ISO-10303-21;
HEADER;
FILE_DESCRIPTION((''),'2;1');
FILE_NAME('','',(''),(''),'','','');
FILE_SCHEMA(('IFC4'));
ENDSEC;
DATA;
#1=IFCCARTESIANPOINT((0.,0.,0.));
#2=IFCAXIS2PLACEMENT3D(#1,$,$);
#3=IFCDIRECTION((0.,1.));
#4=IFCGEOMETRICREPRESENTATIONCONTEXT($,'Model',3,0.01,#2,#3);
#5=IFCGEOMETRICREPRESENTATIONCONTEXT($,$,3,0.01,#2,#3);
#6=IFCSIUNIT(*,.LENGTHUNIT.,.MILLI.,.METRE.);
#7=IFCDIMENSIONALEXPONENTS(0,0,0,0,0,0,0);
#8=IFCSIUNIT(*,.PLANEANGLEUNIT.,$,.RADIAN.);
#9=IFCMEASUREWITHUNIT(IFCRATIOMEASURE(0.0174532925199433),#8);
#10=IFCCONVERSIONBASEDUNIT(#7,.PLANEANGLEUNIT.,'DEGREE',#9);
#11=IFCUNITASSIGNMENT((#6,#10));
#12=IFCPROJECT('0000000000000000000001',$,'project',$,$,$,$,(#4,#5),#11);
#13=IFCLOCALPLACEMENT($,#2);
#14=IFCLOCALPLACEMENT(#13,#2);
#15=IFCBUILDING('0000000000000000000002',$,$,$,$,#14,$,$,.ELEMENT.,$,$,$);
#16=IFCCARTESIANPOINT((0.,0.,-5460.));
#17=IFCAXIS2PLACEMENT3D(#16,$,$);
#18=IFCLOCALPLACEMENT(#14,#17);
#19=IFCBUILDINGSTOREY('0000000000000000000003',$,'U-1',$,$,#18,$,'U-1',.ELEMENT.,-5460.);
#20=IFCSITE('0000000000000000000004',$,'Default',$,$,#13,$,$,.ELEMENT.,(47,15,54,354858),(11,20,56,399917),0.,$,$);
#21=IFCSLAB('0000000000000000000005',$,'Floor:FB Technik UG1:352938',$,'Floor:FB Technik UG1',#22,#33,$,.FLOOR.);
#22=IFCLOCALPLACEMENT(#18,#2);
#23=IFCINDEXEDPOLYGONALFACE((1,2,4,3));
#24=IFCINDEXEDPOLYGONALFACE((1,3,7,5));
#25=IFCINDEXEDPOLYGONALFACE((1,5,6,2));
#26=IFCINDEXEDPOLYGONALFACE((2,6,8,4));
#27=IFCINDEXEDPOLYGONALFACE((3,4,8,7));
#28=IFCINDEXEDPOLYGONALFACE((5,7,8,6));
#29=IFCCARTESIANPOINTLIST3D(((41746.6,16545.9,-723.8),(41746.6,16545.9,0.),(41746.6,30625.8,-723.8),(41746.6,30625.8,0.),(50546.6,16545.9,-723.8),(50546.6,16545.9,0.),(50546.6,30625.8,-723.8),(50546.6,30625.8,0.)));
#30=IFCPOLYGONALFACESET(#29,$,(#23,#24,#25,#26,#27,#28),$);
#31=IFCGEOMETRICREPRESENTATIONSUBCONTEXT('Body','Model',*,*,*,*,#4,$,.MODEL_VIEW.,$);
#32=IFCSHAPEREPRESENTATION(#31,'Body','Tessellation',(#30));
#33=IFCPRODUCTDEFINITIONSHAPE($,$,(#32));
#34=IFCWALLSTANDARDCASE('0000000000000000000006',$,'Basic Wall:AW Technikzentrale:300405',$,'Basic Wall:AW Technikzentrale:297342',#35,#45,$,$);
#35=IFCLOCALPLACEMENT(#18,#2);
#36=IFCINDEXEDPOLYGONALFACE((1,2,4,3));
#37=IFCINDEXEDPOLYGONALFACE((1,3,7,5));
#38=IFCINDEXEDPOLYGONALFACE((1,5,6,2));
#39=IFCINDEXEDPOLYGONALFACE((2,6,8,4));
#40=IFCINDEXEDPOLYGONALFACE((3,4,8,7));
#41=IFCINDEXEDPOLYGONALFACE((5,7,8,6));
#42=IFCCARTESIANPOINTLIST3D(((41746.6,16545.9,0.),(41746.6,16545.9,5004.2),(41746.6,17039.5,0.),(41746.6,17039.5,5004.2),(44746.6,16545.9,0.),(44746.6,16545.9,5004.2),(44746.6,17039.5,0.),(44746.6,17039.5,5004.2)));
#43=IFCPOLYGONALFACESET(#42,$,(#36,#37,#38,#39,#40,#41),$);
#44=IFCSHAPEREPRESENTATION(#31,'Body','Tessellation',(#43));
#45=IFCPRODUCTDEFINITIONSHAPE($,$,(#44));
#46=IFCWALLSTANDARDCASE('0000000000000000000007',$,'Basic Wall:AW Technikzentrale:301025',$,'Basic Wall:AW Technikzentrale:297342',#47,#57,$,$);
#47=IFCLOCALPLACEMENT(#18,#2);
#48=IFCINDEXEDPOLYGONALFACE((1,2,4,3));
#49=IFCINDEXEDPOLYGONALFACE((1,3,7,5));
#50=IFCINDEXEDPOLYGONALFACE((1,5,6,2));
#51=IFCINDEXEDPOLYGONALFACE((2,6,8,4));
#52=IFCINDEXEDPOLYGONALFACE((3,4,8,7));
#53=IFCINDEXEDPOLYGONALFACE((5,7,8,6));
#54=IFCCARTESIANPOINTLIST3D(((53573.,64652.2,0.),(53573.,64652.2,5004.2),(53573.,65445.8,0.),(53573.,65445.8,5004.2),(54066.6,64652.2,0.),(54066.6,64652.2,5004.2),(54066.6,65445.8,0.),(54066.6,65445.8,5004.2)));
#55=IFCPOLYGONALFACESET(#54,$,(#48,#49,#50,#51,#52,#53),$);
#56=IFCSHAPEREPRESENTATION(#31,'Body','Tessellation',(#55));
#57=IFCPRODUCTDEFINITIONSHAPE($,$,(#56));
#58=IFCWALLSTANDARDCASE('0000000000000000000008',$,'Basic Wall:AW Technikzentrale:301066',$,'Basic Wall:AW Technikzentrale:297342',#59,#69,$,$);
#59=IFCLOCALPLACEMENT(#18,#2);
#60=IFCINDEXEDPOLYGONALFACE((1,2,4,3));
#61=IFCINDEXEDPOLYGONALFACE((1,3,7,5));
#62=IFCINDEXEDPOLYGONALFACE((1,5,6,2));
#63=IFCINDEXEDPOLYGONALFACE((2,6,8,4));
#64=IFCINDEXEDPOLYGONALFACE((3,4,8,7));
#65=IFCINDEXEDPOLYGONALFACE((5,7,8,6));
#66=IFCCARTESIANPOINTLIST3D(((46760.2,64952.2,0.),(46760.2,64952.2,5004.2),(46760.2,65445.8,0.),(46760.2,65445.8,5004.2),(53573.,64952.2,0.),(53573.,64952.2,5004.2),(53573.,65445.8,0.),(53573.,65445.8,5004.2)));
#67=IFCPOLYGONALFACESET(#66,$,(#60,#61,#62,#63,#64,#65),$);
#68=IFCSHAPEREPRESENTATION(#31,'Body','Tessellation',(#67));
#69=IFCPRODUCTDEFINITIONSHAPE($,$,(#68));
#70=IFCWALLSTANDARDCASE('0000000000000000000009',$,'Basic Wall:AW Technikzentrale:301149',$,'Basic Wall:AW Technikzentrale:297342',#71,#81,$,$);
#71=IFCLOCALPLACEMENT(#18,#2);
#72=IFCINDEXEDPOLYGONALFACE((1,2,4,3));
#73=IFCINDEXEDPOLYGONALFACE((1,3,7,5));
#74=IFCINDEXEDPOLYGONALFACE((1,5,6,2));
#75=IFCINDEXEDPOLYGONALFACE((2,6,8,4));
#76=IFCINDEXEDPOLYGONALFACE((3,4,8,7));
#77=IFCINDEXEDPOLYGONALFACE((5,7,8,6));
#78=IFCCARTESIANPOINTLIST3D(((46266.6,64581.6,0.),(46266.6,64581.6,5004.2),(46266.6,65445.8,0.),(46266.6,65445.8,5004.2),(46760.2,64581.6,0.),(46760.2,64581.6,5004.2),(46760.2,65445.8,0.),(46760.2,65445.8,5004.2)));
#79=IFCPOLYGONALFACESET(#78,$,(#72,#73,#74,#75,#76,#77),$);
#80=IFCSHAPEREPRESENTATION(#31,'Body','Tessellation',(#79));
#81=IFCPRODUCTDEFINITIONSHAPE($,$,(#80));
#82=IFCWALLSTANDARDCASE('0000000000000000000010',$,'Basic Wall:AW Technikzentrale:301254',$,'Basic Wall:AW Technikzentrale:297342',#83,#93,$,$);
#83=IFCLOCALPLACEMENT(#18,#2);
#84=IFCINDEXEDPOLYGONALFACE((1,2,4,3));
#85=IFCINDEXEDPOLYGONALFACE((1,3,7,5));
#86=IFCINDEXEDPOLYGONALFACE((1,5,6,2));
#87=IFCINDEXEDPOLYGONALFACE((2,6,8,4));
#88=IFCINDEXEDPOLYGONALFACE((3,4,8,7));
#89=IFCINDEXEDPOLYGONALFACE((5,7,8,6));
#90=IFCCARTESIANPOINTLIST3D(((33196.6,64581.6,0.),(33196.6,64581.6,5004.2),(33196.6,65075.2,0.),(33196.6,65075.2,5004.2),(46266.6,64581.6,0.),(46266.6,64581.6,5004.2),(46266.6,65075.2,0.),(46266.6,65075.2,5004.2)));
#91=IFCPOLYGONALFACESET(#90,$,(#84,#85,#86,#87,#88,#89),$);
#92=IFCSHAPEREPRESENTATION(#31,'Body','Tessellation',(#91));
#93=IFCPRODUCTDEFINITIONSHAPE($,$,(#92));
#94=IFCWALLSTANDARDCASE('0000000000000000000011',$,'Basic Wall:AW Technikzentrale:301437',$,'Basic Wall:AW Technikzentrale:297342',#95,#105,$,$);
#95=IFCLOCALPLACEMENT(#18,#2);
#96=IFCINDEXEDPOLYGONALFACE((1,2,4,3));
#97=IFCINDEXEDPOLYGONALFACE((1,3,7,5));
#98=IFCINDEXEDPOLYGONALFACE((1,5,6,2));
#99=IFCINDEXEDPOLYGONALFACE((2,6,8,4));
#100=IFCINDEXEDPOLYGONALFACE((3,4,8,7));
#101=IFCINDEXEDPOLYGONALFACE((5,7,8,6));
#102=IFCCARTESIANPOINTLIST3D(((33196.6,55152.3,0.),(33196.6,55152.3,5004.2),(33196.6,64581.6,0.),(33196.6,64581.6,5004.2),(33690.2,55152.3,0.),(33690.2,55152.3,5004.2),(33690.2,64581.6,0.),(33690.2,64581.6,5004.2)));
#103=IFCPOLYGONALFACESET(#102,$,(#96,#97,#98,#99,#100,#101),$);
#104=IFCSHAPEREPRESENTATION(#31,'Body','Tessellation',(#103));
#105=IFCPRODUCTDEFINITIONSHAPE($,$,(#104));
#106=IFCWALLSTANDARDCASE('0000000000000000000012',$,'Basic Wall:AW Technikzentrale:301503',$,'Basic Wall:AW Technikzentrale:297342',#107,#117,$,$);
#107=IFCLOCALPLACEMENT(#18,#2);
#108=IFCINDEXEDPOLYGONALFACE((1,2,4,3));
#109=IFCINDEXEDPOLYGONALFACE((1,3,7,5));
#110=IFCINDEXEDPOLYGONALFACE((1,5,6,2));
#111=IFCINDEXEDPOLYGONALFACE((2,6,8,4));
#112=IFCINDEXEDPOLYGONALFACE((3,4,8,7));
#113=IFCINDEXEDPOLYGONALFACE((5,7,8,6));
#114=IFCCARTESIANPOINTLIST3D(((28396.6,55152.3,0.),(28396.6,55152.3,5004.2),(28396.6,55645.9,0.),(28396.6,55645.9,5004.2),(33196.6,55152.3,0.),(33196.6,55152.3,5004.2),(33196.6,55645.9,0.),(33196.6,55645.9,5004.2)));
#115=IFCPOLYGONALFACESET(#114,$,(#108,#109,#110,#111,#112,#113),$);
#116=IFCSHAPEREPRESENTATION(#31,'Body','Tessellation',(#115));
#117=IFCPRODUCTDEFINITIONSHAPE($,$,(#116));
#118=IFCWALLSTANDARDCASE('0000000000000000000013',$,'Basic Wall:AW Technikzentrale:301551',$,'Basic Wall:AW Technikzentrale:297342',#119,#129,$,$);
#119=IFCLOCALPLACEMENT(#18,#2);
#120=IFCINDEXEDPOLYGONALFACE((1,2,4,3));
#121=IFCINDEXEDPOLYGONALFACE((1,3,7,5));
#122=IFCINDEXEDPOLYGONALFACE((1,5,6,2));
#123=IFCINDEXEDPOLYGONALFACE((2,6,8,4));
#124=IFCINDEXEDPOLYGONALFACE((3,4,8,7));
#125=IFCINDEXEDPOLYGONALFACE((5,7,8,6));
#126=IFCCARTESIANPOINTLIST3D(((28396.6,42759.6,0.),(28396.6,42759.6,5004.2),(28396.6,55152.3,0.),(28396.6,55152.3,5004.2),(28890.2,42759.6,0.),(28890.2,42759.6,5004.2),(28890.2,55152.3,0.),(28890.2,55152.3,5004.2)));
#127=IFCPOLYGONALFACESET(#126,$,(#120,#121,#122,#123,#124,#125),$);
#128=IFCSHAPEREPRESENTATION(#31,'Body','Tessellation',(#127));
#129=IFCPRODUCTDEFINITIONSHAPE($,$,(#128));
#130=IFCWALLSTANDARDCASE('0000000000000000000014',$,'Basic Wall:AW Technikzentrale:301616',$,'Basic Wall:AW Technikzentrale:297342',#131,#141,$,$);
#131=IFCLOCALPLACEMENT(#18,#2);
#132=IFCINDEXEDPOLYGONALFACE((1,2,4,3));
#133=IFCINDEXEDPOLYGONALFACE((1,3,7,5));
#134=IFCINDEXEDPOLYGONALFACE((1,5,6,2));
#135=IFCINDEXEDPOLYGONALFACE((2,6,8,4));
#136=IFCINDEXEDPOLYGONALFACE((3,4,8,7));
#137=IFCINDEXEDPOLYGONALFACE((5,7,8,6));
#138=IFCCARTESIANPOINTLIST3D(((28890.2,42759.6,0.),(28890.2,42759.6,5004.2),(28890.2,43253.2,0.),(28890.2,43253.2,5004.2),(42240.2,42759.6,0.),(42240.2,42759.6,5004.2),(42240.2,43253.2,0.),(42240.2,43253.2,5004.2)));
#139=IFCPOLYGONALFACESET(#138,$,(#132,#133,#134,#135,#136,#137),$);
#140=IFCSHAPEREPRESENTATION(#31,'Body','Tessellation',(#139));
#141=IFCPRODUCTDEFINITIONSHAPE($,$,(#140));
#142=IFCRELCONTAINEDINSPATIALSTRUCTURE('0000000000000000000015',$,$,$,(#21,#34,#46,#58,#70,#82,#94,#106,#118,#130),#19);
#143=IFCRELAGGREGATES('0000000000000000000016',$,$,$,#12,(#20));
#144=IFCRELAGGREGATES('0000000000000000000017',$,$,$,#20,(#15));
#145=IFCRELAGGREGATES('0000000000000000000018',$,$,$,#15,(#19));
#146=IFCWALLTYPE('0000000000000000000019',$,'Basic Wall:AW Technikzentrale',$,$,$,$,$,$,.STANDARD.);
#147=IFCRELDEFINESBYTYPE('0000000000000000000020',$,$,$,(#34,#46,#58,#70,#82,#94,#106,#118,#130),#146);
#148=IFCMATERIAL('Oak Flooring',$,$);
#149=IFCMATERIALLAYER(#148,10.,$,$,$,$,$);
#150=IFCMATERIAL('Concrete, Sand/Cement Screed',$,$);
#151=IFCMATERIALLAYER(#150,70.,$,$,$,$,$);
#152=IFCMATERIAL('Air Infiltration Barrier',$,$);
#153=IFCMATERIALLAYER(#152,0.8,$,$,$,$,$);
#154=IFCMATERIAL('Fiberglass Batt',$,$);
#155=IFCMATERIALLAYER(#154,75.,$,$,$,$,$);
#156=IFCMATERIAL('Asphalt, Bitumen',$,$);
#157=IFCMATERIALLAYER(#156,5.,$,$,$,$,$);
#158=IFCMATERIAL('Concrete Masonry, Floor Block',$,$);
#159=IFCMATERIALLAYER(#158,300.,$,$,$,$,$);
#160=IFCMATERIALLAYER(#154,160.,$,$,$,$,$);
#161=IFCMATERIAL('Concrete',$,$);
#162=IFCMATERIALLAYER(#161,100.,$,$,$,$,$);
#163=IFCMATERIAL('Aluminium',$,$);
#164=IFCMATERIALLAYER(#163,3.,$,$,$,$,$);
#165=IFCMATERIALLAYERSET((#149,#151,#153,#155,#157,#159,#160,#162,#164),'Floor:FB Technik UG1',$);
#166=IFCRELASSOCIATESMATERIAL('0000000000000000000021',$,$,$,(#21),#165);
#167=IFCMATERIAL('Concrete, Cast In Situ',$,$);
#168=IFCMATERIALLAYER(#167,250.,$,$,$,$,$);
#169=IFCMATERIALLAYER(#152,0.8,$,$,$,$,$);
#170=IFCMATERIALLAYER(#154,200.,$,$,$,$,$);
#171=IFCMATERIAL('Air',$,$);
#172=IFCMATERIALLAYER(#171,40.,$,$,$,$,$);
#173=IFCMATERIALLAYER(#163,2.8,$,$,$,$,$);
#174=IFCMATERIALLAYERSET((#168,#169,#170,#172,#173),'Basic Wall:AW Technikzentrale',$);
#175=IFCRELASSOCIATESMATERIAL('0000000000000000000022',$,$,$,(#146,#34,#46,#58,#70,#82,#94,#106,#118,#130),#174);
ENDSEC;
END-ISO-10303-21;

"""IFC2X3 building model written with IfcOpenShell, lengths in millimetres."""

from ifc_helpers import new_model, entity, si_unit, converted_unit, direction, frame, frame_2d, origin, place, context, subcontext, project, spatial, polyline, rectangle, extrude, clip, bounded_halfspace, material, layer, layer_set, layer_usage, type_object, element, save


model = new_model("IFC2X3")

# Units and contexts
model_context = context("Model", 3, precision=0.01, world=origin(), true_north=direction((0.0, 1.0)))
context_of_model = context(None, 3, precision=0.01, world=origin(), true_north=direction((0.0, 1.0)))
body_context = subcontext(model_context, "Body", "Model", "MODEL_VIEW")
ifc_project = project(units=[si_unit("LENGTHUNIT", "METRE", prefix="MILLI"), converted_unit("PLANEANGLEUNIT", "DEGREE", entity("IfcRatioMeasure", 0.0174532925199433), si_unit("PLANEANGLEUNIT", "RADIAN"), dimensions=[0, 0, 0, 0, 0, 0, 0])], contexts=[model_context, context_of_model])

# Site, building, storey
site_placement = place(None, origin())
site = spatial("IfcSite", under=ifc_project, at=site_placement, Name="Default", CompositionType="ELEMENT", RefLatitude=(47, 15, 54, 354858), RefLongitude=(11, 20, 56, 399917), RefElevation=0.0)
building_placement = place(site_placement, origin())
building = spatial("IfcBuilding", under=site, at=building_placement, CompositionType="ELEMENT")
storey_placement = place(building_placement, frame((0.0, 0.0, -5460.0)))
storey = spatial("IfcBuildingStorey", under=building, at=storey_placement, Name="U-1", LongName="U-1", CompositionType="ELEMENT", Elevation=-5460.0)

# Shared definitions
ifc_material_1 = material(Name="Oak Flooring")
ifc_layer_1 = layer(ifc_material_1, 10.0)
ifc_material_2 = material(Name="Concrete, Sand/Cement Screed")
ifc_layer_2 = layer(ifc_material_2, 70.0)
ifc_material_3 = material(Name="Air Infiltration Barrier")
ifc_layer_3 = layer(ifc_material_3, 0.8)
ifc_material_4 = material(Name="Fiberglass Batt")
ifc_layer_4 = layer(ifc_material_4, 75.0)
ifc_material_5 = material(Name="Asphalt, Bitumen")
ifc_layer_5 = layer(ifc_material_5, 5.0)
ifc_material_6 = material(Name="Concrete Masonry, Floor Block")
ifc_layer_6 = layer(ifc_material_6, 300.0)
ifc_layer_7 = layer(ifc_material_4, 160.0)
ifc_material_7 = material(Name="Concrete")
ifc_layer_8 = layer(ifc_material_7, 100.0)
ifc_material_8 = material(Name="Aluminium")
ifc_layer_9 = layer(ifc_material_8, 3.0)
ifc_layer_set_1 = layer_set([ifc_layer_1, ifc_layer_2, ifc_layer_3, ifc_layer_4, ifc_layer_5, ifc_layer_6, ifc_layer_7, ifc_layer_8, ifc_layer_9], Name="Floor:FB Technik UG1")

# Slab
ifc_layer_usage_1 = layer_usage(ifc_layer_set_1, "AXIS3", "POSITIVE", 0.0)
slab_1_placement = place(storey_placement, origin())
element("IfcSlab", 1, at=slab_1_placement, inside=storey, material=ifc_layer_usage_1, Name="Floor:FB Technik UG1:352938", ObjectType="Floor:FB Technik UG1", PredefinedType="FLOOR", context=body_context, shape_type="SweptSolid", body=[
    extrude(rectangle(XDim=14080.0, YDim=8800.0, at=frame_2d((0.0, 0.0), x_axis=(1.0, 0.0))), frame((46146.6, 23585.8, 0.0), z_axis=(0.0, 0.0, -1.0), x_axis=(0.0, 1.0, 0.0)), (0.0, 0.0, 1.0), 723.8),
])

# Walls
ifc_material_9 = material(Name="Concrete, Cast In Situ")
ifc_layer_10 = layer(ifc_material_9, 250.0)
ifc_layer_11 = layer(ifc_material_3, 0.8)
ifc_layer_12 = layer(ifc_material_4, 200.0)
ifc_material_10 = material(Name="Air")
ifc_layer_13 = layer(ifc_material_10, 40.0)
ifc_layer_14 = layer(ifc_material_8, 2.8)
ifc_layer_set_2 = layer_set([ifc_layer_10, ifc_layer_11, ifc_layer_12, ifc_layer_13, ifc_layer_14], Name="Basic Wall:AW Technikzentrale")
ifc_layer_usage_2 = layer_usage(ifc_layer_set_2, "AXIS2", "NEGATIVE", 246.8)
wall_type_1 = type_object("IfcWallType", Name="Basic Wall:AW Technikzentrale", PredefinedType="STANDARD", material=ifc_layer_set_2)
wall_1_placement = place(storey_placement, frame((41746.6, 16792.7, 0.0)))
element("IfcWallStandardCase", 2, at=wall_1_placement, inside=storey, type_object=wall_type_1, material=ifc_layer_usage_2, Name="Basic Wall:AW Technikzentrale:300405", ObjectType="Basic Wall:AW Technikzentrale:297342", context=body_context, shape_type="Clipping", body=[
    clip(extrude(rectangle(XDim=3000.0, YDim=493.6, at=frame_2d((1500.0, 0.0), x_axis=(-1.0, 0.0))), origin(), (0.0, 0.0, 1.0), 5004.2), bounded_halfspace(frame((0.0, -246.8, 5004.2), z_axis=(0.0, 0.0, -1.0), x_axis=(0.0, -1.0, 0.0)), True, frame((0.0, -246.8, 5004.2)), polyline([(0.0, 0.0), (3000.0, 0.0), (3000.0, 493.6), (493.6, 493.6), (0.0, 493.6), (0.0, 0.0)]))),
])
ifc_layer_usage_3 = layer_usage(ifc_layer_set_2, "AXIS2", "NEGATIVE", 246.8)
wall_2_placement = place(storey_placement, frame((53819.8, 64652.2, 0.0), z_axis=(0.0, 0.0, 1.0), x_axis=(0.0, 1.0, 0.0)))
element("IfcWallStandardCase", 3, at=wall_2_placement, inside=storey, type_object=wall_type_1, material=ifc_layer_usage_3, Name="Basic Wall:AW Technikzentrale:301025", ObjectType="Basic Wall:AW Technikzentrale:297342", context=body_context, shape_type="Clipping", body=[
    clip(extrude(rectangle(XDim=793.6, YDim=493.6, at=frame_2d((396.8, 0.0), x_axis=(-1.0, 0.0))), origin(), (0.0, 0.0, 1.0), 5004.2), bounded_halfspace(frame((0.0, -246.8, 5004.2), z_axis=(0.0, 0.0, -1.0), x_axis=(-1.0, 0.0, 0.0)), True, frame((0.0, -246.8, 5004.2)), polyline([(0.0, 0.0), (493.6, 0.0), (793.6, 0.0), (793.6, 493.6), (300.0, 493.6), (0.0, 493.6), (0.0, 0.0)]))),
])
ifc_layer_usage_4 = layer_usage(ifc_layer_set_2, "AXIS2", "NEGATIVE", 246.8)
wall_3_placement = place(storey_placement, frame((53573.0, 65199.0, 0.0), z_axis=(0.0, 0.0, 1.0), x_axis=(-1.0, 0.0, 0.0)))
element("IfcWallStandardCase", 4, at=wall_3_placement, inside=storey, type_object=wall_type_1, material=ifc_layer_usage_4, Name="Basic Wall:AW Technikzentrale:301066", ObjectType="Basic Wall:AW Technikzentrale:297342", context=body_context, shape_type="Clipping", body=[
    clip(extrude(rectangle(XDim=6812.8, YDim=493.6, at=frame_2d((3406.4, 0.0), x_axis=(-1.0, 0.0))), origin(), (0.0, 0.0, 1.0), 5004.2), bounded_halfspace(frame((0.0, -246.8, 5004.2), z_axis=(0.0, 0.0, -1.0), x_axis=(0.0, 1.0, 0.0)), True, frame((0.0, -246.8, 5004.2)), polyline([(0.0, 0.0), (6812.8, 0.0), (6812.8, 493.6), (0.0, 493.6), (0.0, 0.0)]))),
])
ifc_layer_usage_5 = layer_usage(ifc_layer_set_2, "AXIS2", "NEGATIVE", 246.8)
wall_4_placement = place(storey_placement, frame((46513.4, 65445.8, 0.0), z_axis=(0.0, 0.0, 1.0), x_axis=(0.0, -1.0, 0.0)))
element("IfcWallStandardCase", 5, at=wall_4_placement, inside=storey, type_object=wall_type_1, material=ifc_layer_usage_5, Name="Basic Wall:AW Technikzentrale:301149", ObjectType="Basic Wall:AW Technikzentrale:297342", context=body_context, shape_type="Clipping", body=[
    clip(extrude(rectangle(XDim=864.2, YDim=493.6, at=frame_2d((432.1, 0.0), x_axis=(-1.0, 0.0))), origin(), (0.0, 0.0, 1.0), 5004.2), bounded_halfspace(frame((0.0, -246.8, 5004.2), z_axis=(0.0, 0.0, -1.0), x_axis=(1.0, 0.0, 0.0)), True, frame((0.0, -246.8, 5004.2)), polyline([(0.0, 0.0), (370.6, 0.0), (864.2, 0.0), (864.2, 493.6), (493.6, 493.6), (0.0, 493.6), (0.0, 0.0)]))),
])
ifc_layer_usage_6 = layer_usage(ifc_layer_set_2, "AXIS2", "NEGATIVE", 246.8)
wall_5_placement = place(storey_placement, frame((46266.6, 64828.4, 0.0), z_axis=(0.0, 0.0, 1.0), x_axis=(-1.0, 0.0, 0.0)))
element("IfcWallStandardCase", 6, at=wall_5_placement, inside=storey, type_object=wall_type_1, material=ifc_layer_usage_6, Name="Basic Wall:AW Technikzentrale:301254", ObjectType="Basic Wall:AW Technikzentrale:297342", context=body_context, shape_type="Clipping", body=[
    clip(extrude(rectangle(XDim=13070.0, YDim=493.6, at=frame_2d((6535.0, 0.0), x_axis=(-1.0, 0.0))), origin(), (0.0, 0.0, 1.0), 5004.2), bounded_halfspace(frame((0.0, -246.8, 5004.2), z_axis=(0.0, 0.0, -1.0), x_axis=(0.0, 1.0, 0.0)), True, frame((0.0, -246.8, 5004.2)), polyline([(0.0, 0.0), (13070.0, 0.0), (13070.0, 493.6), (12576.4, 493.6), (0.0, 493.6), (0.0, 0.0)]))),
])
ifc_layer_usage_7 = layer_usage(ifc_layer_set_2, "AXIS2", "NEGATIVE", 246.8)
wall_6_placement = place(storey_placement, frame((33443.4, 64581.6, 0.0), z_axis=(0.0, 0.0, 1.0), x_axis=(0.0, -1.0, 0.0)))
element("IfcWallStandardCase", 7, at=wall_6_placement, inside=storey, type_object=wall_type_1, material=ifc_layer_usage_7, Name="Basic Wall:AW Technikzentrale:301437", ObjectType="Basic Wall:AW Technikzentrale:297342", context=body_context, shape_type="Clipping", body=[
    clip(extrude(rectangle(XDim=9429.4, YDim=493.6, at=frame_2d((4714.7, 0.0), x_axis=(-1.0, 0.0))), origin(), (0.0, 0.0, 1.0), 5004.2), bounded_halfspace(frame((0.0, -246.8, 5004.2), z_axis=(0.0, 0.0, -1.0), x_axis=(1.0, 0.0, 0.0)), True, frame((0.0, -246.8, 5004.2)), polyline([(0.0, 0.0), (8935.8, 0.0), (9429.4, 0.0), (9429.4, 493.6), (9180.8, 493.6), (8980.8, 493.6), (0.0, 493.6), (0.0, 0.0)]))),
])
ifc_layer_usage_8 = layer_usage(ifc_layer_set_2, "AXIS2", "NEGATIVE", 246.8)
wall_7_placement = place(storey_placement, frame((33196.6, 55399.1, 0.0), z_axis=(0.0, 0.0, 1.0), x_axis=(-1.0, 0.0, 0.0)))
element("IfcWallStandardCase", 8, at=wall_7_placement, inside=storey, type_object=wall_type_1, material=ifc_layer_usage_8, Name="Basic Wall:AW Technikzentrale:301503", ObjectType="Basic Wall:AW Technikzentrale:297342", context=body_context, shape_type="Clipping", body=[
    clip(extrude(rectangle(XDim=4800.0, YDim=493.6, at=frame_2d((2400.0, 0.0), x_axis=(-1.0, 0.0))), origin(), (0.0, 0.0, 1.0), 5004.2), bounded_halfspace(frame((0.0, -246.8, 5004.2), z_axis=(0.0, 0.0, -1.0), x_axis=(0.0, 1.0, 0.0)), True, frame((0.0, -246.8, 5004.2)), polyline([(0.0, 0.0), (4800.0, 0.0), (4800.0, 493.6), (4306.4, 493.6), (0.0, 493.6), (0.0, 0.0)]))),
])
ifc_layer_usage_9 = layer_usage(ifc_layer_set_2, "AXIS2", "NEGATIVE", 246.8)
wall_8_placement = place(storey_placement, frame((28643.4, 55152.3, 0.0), z_axis=(0.0, 0.0, 1.0), x_axis=(0.0, -1.0, 0.0)))
element("IfcWallStandardCase", 9, at=wall_8_placement, inside=storey, type_object=wall_type_1, material=ifc_layer_usage_9, Name="Basic Wall:AW Technikzentrale:301551", ObjectType="Basic Wall:AW Technikzentrale:297342", context=body_context, shape_type="Clipping", body=[
    clip(extrude(rectangle(XDim=12392.6, YDim=493.6, at=frame_2d((6196.3, 0.0), x_axis=(-1.0, 0.0))), origin(), (0.0, 0.0, 1.0), 5004.2), bounded_halfspace(frame((0.0, -246.8, 5004.2), z_axis=(0.0, 0.0, -1.0), x_axis=(1.0, 0.0, 0.0)), True, frame((0.0, -246.8, 5004.2)), polyline([(0.0, 0.0), (12392.6, 0.0), (12392.6, 493.6), (11899.0, 493.6), (0.0, 493.6), (0.0, 0.0)]))),
])
ifc_layer_usage_10 = layer_usage(ifc_layer_set_2, "AXIS2", "NEGATIVE", 246.8)
wall_9_placement = place(storey_placement, frame((28890.2, 43006.4, 0.0)))
element("IfcWallStandardCase", 10, at=wall_9_placement, inside=storey, type_object=wall_type_1, material=ifc_layer_usage_10, Name="Basic Wall:AW Technikzentrale:301616", ObjectType="Basic Wall:AW Technikzentrale:297342", context=body_context, shape_type="Clipping", body=[
    clip(extrude(rectangle(XDim=13350.0, YDim=493.6, at=frame_2d((6675.0, 0.0), x_axis=(-1.0, 0.0))), origin(), (0.0, 0.0, 1.0), 5004.2), bounded_halfspace(frame((0.0, -246.8, 5004.2), z_axis=(0.0, 0.0, -1.0), x_axis=(0.0, -1.0, 0.0)), True, frame((0.0, -246.8, 5004.2)), polyline([(0.0, 0.0), (12856.4, 0.0), (12856.4, 493.6), (0.0, 493.6), (0.0, 0.0)]))),
])

save(model, "model.ifc")
